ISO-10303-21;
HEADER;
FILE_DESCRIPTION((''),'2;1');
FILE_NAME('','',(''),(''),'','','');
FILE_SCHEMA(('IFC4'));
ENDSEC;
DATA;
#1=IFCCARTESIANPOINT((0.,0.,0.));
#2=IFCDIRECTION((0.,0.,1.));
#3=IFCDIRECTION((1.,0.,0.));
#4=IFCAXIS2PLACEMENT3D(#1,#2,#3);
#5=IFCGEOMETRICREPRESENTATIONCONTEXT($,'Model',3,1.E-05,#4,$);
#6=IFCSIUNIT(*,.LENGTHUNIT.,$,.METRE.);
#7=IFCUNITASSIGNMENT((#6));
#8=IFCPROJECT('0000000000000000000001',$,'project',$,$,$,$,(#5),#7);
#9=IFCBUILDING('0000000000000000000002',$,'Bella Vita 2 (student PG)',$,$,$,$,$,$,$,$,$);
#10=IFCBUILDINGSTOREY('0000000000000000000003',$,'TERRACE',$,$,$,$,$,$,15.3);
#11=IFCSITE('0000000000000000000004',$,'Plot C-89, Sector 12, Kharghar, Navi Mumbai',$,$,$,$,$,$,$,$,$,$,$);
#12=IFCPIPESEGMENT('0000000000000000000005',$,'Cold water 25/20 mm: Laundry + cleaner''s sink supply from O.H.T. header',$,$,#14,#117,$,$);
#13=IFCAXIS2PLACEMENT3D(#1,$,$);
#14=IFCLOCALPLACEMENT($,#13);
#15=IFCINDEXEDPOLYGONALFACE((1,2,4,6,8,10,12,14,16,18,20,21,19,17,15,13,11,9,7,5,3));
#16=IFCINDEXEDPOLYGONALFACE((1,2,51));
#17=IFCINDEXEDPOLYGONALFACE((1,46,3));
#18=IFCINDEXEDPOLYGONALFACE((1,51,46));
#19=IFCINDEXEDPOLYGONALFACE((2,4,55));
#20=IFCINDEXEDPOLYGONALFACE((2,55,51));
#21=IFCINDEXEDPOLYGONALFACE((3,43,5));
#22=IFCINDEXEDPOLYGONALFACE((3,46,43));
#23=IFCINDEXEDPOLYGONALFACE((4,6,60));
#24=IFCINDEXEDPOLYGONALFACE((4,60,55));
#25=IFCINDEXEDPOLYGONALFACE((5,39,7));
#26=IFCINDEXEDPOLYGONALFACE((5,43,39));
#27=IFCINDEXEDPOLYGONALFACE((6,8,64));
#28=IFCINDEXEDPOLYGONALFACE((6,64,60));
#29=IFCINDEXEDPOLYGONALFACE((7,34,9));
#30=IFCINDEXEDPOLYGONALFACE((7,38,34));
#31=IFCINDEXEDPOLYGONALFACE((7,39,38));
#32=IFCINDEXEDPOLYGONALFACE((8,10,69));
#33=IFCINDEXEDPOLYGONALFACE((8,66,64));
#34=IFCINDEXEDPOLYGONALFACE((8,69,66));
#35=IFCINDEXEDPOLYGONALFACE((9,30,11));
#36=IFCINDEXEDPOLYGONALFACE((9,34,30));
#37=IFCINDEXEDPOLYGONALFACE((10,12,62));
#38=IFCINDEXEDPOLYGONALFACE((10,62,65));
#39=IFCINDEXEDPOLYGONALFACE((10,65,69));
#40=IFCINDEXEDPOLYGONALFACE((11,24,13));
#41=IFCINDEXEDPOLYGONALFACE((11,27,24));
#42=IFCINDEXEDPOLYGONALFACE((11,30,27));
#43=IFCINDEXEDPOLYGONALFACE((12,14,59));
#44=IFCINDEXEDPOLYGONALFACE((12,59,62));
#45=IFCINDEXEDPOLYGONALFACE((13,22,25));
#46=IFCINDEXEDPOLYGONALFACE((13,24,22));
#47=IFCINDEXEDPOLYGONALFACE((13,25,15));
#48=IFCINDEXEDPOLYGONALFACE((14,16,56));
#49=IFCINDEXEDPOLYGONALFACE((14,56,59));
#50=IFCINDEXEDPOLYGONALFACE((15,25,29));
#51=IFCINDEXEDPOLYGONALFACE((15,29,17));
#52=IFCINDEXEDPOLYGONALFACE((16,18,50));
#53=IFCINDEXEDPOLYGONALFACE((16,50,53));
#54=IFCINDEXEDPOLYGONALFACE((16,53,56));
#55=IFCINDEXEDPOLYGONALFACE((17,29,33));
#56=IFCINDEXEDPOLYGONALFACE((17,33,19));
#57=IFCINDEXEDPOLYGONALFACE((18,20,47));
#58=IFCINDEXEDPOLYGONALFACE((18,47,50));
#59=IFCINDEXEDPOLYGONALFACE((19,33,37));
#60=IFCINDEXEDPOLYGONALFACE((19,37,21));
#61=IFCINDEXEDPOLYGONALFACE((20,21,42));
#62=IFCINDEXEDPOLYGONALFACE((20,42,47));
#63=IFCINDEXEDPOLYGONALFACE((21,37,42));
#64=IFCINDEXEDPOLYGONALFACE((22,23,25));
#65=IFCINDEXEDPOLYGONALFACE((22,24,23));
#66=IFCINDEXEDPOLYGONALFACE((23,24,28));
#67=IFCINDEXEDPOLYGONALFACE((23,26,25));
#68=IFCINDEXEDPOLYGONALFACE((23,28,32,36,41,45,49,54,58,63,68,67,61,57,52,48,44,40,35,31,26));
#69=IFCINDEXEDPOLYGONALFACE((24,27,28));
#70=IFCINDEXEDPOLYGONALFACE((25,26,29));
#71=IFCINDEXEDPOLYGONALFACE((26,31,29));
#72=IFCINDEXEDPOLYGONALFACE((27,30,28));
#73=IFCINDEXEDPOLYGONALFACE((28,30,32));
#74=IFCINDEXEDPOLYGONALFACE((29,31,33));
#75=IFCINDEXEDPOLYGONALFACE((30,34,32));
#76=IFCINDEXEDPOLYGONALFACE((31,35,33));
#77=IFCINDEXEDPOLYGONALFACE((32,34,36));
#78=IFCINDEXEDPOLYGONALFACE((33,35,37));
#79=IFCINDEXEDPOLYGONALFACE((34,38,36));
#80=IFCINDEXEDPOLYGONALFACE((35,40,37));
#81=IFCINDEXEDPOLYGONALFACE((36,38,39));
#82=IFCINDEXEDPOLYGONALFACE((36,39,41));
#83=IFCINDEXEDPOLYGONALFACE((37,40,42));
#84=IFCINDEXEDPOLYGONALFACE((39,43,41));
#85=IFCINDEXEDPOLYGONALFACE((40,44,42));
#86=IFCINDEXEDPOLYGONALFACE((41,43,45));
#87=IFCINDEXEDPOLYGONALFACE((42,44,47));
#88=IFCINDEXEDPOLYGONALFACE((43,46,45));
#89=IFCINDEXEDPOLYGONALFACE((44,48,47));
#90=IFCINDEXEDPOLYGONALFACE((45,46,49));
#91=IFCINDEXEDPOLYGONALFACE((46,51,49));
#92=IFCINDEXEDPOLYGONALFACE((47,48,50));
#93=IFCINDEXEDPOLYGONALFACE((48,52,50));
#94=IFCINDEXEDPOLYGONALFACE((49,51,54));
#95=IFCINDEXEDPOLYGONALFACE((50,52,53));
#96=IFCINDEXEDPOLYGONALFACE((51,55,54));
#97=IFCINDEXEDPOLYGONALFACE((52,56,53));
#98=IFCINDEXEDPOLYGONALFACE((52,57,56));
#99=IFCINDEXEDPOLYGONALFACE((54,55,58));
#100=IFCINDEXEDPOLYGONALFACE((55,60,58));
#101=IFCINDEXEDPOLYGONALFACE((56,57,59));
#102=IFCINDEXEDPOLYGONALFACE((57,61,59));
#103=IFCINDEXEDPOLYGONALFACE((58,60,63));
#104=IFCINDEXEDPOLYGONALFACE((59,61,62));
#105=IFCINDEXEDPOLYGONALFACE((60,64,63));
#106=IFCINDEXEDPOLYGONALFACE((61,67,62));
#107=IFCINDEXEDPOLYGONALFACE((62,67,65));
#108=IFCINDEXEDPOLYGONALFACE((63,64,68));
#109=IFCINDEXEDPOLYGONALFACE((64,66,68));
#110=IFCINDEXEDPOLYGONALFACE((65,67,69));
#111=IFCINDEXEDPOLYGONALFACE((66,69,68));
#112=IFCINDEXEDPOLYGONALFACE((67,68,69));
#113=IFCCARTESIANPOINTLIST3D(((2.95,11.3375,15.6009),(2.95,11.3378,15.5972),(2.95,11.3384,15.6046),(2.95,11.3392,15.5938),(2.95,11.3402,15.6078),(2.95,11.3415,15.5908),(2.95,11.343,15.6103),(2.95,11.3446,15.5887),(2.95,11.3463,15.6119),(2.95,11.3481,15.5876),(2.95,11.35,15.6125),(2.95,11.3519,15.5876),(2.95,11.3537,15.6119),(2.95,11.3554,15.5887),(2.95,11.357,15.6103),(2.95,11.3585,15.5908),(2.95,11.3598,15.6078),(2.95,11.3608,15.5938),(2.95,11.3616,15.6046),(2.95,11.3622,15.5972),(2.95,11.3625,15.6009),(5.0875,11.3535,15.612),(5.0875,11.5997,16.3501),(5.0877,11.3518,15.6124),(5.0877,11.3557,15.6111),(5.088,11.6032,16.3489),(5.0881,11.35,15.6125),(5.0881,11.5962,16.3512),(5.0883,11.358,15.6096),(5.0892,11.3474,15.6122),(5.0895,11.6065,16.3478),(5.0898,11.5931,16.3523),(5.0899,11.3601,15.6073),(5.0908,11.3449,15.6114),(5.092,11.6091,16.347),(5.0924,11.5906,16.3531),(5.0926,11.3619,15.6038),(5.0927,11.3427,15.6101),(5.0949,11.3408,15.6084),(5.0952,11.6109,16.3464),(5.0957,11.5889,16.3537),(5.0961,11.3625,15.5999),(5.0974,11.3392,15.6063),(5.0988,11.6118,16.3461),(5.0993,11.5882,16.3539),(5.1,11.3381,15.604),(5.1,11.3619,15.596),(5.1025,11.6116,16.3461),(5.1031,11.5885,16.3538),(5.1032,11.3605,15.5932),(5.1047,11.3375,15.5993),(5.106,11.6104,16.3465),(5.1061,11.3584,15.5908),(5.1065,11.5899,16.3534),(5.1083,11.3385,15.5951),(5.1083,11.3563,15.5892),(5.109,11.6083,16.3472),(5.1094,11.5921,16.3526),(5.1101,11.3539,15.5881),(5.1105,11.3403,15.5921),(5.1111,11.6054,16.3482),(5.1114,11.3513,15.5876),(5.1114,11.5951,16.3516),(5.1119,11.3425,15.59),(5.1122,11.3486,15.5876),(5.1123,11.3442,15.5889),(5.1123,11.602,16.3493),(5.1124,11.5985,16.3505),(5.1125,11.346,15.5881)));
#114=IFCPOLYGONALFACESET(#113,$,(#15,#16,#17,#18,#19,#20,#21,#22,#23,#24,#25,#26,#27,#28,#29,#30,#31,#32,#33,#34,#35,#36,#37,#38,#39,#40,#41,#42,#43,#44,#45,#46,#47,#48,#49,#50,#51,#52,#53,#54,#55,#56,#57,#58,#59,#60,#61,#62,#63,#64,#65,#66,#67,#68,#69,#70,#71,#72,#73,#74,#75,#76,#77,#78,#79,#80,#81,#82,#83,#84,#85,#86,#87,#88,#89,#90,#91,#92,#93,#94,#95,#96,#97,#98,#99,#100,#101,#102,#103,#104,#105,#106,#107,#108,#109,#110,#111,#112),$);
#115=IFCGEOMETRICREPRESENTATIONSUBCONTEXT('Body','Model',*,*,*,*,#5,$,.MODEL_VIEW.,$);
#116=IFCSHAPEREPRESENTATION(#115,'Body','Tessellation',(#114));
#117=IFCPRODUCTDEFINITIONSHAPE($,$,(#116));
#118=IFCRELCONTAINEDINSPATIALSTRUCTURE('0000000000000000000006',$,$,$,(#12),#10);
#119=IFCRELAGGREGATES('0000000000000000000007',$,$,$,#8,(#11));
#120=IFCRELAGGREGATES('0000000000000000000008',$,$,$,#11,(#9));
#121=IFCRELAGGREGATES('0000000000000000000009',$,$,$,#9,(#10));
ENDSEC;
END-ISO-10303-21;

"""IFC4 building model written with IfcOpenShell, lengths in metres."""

from ifc_helpers import new_model, entity, si_unit, origin, origin_with_axes, place, context, subcontext, project, spatial, element, save


model = new_model("IFC4")

# Units and contexts
model_context = context("Model", 3, precision=1e-05, world=origin_with_axes())
body_context = subcontext(model_context, "Body", "Model", "MODEL_VIEW")
ifc_project = project(units=[si_unit("LENGTHUNIT", "METRE")], contexts=[model_context])

# Site, building, storey
site = spatial("IfcSite", under=ifc_project, Name="Plot C-89, Sector 12, Kharghar, Navi Mumbai")
building = spatial("IfcBuilding", under=site, Name="Bella Vita 2 (student PG)")
storey = spatial("IfcBuildingStorey", under=building, Name="TERRACE", Elevation=15.3)

# Pipe segment
pipe_segment_1_placement = place(None, origin())
element("IfcPipeSegment", 1, at=pipe_segment_1_placement, inside=storey, Name="Cold water 25/20 mm: Laundry + cleaner's sink supply from O.H.T. header", context=body_context, shape_type="AdvancedSweptSolid", body=[
    entity("IfcSweptDiskSolid", entity("IfcPolyline", [entity("IfcCartesianPoint", [2.95, 11.35, 15.6]), entity("IfcCartesianPoint", [5.1, 11.35, 15.6]), entity("IfcCartesianPoint", [5.1, 11.6, 16.35])]), 0.0125),
])

save(model, "model.ifc")
